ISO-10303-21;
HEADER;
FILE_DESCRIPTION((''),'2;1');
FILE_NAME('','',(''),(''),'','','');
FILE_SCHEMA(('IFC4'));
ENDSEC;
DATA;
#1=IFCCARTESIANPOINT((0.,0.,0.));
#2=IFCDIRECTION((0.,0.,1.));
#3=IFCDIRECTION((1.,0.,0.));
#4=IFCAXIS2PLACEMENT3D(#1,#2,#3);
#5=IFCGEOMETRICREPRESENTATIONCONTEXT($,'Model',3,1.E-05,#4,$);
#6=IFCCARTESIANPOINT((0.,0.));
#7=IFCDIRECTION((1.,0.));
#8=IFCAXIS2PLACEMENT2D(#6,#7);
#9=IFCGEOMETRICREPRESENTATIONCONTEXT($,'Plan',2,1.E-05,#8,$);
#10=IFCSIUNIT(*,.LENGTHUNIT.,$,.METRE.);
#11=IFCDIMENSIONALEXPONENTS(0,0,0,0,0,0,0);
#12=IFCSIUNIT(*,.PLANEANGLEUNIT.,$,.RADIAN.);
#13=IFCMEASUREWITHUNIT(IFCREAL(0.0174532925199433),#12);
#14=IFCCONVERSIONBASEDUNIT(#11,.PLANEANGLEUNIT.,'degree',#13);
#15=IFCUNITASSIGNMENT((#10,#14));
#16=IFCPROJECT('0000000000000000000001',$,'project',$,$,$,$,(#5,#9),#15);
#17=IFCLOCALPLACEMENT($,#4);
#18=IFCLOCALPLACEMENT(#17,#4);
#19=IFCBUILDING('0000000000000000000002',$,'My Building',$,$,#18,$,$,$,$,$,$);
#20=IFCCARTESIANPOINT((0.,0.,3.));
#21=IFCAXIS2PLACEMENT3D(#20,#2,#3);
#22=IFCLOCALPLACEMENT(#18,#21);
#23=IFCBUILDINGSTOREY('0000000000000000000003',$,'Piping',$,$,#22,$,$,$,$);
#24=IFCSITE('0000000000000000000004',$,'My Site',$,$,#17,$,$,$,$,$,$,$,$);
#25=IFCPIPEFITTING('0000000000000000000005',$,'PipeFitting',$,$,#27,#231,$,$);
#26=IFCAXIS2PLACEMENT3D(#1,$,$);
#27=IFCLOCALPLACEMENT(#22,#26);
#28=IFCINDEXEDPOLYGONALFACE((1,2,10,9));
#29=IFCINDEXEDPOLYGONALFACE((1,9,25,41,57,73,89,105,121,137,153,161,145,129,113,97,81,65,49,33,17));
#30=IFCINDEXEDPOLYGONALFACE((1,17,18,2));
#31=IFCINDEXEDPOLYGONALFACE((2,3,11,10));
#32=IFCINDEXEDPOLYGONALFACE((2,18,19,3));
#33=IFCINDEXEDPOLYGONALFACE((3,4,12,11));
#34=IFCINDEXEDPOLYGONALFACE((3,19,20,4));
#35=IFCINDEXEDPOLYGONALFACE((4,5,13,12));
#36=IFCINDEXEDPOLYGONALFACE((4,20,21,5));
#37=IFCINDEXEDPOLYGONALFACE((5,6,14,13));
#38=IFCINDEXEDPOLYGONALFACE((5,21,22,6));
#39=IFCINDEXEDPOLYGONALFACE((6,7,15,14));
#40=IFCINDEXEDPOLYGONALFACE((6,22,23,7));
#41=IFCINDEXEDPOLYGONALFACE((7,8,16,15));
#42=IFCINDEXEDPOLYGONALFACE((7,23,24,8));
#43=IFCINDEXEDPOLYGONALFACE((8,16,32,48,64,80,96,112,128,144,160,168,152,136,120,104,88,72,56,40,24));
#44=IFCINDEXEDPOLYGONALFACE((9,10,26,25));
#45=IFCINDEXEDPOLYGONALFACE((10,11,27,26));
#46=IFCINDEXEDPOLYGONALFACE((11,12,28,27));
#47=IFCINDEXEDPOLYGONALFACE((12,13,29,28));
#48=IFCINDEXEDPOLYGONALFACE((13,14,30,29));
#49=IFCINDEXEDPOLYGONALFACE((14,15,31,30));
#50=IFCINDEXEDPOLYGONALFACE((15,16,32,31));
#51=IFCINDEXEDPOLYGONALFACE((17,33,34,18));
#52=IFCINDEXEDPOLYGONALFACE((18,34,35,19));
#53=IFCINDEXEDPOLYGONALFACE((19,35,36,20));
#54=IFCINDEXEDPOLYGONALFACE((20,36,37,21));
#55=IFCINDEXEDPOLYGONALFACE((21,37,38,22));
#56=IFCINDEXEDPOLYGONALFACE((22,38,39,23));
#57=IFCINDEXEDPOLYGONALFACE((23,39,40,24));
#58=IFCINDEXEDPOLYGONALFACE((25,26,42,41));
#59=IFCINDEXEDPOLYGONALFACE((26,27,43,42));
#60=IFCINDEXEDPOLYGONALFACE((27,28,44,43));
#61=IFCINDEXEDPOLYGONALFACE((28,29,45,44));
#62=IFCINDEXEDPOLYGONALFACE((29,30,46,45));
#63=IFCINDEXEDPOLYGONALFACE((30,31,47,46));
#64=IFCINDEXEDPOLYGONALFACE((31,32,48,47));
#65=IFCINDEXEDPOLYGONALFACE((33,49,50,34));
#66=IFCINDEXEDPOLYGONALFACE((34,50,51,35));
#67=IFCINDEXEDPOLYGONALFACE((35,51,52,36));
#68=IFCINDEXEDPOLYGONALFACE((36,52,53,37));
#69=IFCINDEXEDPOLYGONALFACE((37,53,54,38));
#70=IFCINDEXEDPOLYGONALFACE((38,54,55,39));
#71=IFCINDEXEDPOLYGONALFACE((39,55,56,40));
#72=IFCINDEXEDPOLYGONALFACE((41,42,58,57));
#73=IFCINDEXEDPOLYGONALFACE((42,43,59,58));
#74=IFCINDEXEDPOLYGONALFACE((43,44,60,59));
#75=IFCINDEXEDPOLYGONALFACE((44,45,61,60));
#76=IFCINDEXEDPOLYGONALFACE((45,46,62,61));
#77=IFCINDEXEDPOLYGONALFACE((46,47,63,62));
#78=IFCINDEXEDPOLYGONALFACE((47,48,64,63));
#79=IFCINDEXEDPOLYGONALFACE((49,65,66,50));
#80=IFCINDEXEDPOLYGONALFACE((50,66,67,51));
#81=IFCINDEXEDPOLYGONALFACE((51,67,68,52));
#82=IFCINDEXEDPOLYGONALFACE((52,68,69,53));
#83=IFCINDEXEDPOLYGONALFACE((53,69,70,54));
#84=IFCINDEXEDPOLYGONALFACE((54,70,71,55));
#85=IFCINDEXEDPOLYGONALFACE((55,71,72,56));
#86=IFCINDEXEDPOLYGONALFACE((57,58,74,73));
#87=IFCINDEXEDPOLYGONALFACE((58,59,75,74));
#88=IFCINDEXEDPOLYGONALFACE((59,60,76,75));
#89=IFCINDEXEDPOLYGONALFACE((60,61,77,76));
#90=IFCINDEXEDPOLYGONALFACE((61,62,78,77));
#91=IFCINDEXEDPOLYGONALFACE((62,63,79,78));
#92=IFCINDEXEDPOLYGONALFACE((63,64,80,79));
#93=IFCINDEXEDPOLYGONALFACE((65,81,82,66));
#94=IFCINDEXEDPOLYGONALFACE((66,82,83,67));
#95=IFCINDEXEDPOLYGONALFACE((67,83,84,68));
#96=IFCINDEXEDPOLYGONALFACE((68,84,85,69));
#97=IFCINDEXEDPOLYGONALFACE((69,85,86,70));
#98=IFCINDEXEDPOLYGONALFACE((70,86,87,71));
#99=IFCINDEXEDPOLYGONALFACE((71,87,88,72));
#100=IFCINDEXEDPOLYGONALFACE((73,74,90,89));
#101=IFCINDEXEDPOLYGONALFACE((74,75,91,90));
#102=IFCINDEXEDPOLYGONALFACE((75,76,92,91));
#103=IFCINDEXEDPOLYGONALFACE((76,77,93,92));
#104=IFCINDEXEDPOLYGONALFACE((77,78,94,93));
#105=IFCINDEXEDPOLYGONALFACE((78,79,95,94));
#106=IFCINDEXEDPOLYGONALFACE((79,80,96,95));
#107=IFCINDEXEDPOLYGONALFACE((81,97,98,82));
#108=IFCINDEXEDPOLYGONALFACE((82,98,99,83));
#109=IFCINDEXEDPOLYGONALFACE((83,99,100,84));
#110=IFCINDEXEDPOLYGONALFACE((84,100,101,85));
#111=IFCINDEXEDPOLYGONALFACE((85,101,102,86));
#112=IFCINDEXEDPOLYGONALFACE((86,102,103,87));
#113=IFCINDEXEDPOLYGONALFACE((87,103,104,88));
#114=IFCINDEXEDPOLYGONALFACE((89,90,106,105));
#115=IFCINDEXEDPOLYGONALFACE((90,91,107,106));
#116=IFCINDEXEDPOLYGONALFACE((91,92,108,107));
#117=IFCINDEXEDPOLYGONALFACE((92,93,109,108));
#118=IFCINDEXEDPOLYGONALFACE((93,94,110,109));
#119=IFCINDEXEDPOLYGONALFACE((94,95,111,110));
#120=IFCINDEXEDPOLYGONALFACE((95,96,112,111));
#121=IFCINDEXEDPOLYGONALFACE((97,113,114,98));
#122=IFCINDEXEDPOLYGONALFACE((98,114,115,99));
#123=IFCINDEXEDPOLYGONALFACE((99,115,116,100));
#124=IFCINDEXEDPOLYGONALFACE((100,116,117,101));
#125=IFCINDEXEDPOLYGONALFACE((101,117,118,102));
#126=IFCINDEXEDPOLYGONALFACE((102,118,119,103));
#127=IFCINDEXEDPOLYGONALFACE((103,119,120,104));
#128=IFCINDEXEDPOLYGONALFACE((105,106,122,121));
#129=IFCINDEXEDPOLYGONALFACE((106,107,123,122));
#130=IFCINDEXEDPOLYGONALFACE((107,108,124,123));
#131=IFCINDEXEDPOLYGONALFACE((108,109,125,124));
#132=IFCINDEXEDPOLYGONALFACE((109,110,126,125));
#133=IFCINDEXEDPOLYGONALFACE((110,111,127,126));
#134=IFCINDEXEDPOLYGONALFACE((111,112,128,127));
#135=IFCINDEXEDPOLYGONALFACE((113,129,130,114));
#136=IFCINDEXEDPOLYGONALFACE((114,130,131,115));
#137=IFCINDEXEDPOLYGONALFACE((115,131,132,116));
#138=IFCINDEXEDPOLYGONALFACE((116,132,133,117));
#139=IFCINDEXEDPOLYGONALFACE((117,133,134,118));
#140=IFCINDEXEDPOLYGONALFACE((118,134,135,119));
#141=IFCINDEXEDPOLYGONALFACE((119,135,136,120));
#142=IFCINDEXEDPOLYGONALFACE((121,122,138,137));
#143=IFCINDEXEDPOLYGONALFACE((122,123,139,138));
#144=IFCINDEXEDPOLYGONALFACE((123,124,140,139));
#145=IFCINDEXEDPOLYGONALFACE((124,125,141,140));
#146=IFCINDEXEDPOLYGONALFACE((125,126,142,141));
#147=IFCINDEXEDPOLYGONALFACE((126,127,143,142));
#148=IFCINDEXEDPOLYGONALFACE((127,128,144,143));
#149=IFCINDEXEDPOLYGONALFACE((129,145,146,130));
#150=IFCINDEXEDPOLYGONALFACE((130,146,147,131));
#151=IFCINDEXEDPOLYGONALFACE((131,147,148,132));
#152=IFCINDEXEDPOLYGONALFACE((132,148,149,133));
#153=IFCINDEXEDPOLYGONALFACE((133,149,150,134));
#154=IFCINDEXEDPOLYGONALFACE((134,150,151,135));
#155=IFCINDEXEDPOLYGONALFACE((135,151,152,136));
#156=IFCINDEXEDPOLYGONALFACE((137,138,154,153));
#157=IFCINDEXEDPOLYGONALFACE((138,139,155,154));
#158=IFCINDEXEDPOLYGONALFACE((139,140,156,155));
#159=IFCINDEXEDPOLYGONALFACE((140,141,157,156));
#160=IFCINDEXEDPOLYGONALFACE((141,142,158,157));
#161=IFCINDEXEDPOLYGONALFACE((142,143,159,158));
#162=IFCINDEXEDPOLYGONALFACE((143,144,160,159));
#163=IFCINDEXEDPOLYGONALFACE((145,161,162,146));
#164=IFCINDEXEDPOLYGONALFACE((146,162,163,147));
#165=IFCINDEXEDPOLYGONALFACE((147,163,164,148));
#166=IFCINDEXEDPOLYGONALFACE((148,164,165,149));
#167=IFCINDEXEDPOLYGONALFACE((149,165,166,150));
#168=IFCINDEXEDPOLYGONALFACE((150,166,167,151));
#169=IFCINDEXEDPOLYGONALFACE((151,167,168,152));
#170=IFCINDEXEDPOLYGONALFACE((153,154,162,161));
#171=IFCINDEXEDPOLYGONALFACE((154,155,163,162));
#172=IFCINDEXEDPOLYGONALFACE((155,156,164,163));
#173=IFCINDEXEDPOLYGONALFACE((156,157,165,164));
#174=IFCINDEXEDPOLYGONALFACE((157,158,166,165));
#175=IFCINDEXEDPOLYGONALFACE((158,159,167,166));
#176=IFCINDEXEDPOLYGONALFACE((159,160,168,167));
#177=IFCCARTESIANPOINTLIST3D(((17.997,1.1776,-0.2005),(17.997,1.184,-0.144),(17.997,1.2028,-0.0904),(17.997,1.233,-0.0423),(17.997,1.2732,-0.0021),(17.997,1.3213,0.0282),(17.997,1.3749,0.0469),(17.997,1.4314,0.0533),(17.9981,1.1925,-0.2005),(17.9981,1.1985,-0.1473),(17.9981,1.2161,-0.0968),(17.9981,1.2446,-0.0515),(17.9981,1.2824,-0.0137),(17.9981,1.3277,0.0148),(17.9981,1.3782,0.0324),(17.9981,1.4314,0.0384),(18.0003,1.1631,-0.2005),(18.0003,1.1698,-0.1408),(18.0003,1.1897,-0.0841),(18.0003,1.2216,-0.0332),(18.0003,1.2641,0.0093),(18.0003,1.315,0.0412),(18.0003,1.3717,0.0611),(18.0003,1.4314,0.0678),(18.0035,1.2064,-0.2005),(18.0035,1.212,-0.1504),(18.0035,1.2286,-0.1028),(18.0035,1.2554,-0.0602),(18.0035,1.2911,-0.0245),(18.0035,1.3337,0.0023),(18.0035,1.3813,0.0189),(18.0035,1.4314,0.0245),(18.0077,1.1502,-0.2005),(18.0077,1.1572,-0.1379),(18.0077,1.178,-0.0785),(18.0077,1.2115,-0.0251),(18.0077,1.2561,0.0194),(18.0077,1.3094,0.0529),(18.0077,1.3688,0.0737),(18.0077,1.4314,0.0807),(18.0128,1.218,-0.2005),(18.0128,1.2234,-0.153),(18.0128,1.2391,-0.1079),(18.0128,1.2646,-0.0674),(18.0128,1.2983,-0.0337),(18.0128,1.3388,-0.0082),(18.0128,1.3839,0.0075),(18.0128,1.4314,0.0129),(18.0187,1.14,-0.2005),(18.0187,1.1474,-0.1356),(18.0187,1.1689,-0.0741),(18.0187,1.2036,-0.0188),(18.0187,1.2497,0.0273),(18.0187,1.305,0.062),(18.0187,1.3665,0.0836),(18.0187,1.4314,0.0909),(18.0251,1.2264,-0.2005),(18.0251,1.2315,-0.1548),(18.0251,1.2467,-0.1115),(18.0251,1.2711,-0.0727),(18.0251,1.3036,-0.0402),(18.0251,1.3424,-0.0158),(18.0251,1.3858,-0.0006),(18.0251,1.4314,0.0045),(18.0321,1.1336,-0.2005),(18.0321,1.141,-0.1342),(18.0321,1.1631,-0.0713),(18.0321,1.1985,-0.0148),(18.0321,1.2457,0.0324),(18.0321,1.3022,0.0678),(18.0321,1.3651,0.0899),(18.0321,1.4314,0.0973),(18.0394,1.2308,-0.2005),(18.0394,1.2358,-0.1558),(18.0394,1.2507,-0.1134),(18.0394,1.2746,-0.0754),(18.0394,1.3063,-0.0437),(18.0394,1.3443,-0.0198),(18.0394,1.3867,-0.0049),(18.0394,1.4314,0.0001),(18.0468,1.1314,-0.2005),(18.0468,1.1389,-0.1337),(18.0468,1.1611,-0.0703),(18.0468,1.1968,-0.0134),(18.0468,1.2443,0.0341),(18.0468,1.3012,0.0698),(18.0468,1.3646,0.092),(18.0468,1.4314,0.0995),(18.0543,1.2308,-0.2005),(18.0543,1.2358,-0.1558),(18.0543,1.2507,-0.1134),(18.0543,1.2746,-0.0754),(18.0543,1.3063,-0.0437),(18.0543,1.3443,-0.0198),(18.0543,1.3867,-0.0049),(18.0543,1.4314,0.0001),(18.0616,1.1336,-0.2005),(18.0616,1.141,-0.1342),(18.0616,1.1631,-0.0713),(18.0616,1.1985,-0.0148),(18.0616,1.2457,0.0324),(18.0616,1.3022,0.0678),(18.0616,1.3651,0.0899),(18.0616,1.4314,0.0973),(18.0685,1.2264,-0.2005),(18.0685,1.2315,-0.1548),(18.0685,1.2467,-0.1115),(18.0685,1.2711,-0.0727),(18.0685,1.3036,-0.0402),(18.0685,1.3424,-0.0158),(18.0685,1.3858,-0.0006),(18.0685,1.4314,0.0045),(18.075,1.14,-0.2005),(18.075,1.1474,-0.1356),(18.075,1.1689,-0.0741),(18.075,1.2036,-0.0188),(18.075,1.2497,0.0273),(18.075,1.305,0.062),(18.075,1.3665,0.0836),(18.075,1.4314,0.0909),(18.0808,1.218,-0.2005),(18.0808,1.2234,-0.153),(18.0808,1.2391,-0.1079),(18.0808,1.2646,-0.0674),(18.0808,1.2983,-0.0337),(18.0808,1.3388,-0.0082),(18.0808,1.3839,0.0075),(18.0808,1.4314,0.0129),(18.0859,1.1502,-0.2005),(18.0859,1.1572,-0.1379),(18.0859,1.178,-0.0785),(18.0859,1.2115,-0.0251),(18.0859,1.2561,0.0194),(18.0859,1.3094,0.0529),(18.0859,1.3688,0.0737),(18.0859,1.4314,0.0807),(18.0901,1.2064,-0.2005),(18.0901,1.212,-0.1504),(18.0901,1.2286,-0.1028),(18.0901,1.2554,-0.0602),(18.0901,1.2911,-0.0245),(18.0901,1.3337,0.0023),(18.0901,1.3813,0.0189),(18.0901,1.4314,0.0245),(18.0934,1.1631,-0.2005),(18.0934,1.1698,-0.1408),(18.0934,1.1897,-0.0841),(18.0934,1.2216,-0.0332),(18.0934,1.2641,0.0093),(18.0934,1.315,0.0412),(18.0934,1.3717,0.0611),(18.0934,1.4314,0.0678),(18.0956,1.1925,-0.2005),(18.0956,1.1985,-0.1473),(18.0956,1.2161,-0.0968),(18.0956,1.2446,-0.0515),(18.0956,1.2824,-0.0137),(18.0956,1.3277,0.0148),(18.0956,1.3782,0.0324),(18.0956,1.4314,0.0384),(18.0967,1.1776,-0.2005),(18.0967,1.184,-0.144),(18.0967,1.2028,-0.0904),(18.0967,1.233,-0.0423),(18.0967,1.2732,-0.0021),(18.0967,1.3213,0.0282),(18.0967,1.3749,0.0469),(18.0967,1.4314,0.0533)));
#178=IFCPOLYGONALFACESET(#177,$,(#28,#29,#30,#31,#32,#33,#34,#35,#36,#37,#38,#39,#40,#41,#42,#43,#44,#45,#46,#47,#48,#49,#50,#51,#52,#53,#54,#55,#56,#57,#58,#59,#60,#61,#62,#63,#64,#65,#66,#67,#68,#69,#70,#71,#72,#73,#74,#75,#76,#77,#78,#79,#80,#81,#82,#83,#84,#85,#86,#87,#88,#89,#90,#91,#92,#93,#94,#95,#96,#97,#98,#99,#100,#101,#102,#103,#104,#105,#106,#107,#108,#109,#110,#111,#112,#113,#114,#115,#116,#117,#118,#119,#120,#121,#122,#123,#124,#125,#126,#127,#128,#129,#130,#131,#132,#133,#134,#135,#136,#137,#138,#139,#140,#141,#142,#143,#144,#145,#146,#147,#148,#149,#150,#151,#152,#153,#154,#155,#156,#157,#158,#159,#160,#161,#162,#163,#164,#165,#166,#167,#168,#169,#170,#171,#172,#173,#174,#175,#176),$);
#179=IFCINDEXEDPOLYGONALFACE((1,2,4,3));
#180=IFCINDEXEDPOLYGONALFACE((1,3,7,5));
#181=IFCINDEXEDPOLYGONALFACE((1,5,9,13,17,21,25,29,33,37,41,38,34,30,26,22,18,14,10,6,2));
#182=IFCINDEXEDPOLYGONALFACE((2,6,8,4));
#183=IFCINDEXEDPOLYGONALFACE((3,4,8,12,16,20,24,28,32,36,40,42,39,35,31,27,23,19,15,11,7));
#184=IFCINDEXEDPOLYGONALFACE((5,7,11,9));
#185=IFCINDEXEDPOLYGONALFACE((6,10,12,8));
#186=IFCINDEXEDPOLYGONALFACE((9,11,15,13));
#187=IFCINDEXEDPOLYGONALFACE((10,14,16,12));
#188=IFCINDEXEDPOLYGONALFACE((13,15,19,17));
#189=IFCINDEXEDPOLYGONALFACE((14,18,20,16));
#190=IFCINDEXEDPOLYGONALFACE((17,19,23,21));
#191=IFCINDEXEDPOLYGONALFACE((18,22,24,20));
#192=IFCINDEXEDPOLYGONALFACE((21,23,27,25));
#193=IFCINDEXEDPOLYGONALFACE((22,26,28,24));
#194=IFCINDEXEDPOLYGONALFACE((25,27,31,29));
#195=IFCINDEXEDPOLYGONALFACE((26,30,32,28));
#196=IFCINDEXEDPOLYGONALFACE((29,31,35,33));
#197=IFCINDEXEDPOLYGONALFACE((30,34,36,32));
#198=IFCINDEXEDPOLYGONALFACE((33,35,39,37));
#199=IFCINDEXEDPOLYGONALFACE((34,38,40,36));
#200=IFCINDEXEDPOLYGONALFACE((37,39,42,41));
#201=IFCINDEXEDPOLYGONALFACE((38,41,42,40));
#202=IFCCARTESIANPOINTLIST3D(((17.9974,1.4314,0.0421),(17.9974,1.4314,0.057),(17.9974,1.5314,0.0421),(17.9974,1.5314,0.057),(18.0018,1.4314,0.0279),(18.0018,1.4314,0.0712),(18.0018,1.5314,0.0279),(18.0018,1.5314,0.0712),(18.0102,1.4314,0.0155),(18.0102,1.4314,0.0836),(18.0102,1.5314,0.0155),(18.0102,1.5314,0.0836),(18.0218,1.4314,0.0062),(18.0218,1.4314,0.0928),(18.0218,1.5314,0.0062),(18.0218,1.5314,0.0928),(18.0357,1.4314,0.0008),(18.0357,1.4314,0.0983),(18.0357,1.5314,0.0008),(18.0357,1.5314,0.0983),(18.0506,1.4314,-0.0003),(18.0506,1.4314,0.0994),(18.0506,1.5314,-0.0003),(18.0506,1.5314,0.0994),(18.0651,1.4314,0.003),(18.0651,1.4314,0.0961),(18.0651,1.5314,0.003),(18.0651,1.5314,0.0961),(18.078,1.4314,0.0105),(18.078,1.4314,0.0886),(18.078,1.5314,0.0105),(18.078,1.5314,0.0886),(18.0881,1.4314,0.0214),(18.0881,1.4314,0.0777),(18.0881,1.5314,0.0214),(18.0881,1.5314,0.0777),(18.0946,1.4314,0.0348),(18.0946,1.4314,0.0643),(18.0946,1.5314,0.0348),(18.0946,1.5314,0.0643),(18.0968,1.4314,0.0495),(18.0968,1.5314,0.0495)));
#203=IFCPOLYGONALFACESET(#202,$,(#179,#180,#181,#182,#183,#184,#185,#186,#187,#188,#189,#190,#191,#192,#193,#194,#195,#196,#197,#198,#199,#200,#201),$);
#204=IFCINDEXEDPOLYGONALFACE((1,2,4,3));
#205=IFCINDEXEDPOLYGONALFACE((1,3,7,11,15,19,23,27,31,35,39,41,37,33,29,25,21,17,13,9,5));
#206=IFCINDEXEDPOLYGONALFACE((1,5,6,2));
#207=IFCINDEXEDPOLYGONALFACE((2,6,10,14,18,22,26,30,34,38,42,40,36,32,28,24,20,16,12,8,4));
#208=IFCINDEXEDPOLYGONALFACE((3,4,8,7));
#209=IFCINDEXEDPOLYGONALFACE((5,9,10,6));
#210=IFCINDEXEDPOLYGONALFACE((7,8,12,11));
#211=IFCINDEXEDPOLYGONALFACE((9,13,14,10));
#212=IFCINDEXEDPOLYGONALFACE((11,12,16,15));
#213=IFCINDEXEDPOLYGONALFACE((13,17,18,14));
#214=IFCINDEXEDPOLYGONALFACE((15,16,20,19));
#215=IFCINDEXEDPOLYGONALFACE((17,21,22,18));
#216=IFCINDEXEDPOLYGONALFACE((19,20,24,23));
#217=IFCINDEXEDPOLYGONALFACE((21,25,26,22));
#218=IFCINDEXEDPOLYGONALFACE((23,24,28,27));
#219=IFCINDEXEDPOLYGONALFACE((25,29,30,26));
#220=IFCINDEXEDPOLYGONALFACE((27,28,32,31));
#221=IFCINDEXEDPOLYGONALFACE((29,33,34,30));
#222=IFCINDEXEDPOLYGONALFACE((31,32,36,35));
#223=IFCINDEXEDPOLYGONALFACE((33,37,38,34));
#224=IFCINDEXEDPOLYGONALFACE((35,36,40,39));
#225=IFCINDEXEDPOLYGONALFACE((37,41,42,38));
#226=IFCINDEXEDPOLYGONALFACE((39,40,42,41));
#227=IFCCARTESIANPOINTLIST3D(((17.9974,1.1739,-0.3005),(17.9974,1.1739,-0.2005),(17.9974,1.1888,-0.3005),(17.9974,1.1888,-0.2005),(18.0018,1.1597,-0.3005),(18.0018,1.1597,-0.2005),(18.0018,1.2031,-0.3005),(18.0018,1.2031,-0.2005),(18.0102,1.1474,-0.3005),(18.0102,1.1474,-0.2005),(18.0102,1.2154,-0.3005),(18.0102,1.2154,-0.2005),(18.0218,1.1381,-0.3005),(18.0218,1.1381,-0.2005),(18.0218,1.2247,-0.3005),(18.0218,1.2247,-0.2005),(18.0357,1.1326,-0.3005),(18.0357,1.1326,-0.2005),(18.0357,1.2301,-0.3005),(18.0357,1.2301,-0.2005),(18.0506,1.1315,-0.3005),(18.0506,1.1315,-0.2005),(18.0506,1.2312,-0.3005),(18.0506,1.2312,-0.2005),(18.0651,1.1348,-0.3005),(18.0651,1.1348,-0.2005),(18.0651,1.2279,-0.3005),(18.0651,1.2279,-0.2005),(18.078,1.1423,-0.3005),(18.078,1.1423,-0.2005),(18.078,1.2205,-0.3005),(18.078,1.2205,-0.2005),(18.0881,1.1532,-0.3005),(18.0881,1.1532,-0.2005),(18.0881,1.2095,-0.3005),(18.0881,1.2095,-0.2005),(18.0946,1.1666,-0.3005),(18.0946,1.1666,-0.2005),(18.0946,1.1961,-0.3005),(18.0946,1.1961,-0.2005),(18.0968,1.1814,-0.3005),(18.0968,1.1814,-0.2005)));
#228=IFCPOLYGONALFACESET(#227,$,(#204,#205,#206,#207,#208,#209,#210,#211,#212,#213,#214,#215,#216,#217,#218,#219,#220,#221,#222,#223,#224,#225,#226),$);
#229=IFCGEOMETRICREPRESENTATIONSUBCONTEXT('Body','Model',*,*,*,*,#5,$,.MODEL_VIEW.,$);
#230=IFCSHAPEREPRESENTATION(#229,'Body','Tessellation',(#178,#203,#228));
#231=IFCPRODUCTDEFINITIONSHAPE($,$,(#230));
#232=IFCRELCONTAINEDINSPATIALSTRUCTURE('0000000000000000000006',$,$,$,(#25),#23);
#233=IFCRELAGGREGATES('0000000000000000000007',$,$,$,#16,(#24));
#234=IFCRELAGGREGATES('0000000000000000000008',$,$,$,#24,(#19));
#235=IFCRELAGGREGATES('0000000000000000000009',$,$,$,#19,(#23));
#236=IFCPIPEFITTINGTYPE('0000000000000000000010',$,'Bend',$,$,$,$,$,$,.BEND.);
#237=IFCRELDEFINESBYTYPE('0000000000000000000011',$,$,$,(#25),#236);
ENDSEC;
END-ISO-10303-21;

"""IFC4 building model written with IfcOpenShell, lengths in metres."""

from ifc_helpers import new_model, entity, si_unit, converted_unit, frame, origin_with_axes, origin_2d_with_axis, place, context, subcontext, project, spatial, circle, extrude, source, transform, mapped, type_object, type_shapes, element, save


model = new_model("IFC4")

# Units and contexts
model_context = context("Model", 3, precision=1e-05, world=origin_with_axes())
plan_context = context("Plan", 2, precision=1e-05, world=origin_2d_with_axis())
body_context = subcontext(model_context, "Body", "Model", "MODEL_VIEW")
ifc_project = project(units=[si_unit("LENGTHUNIT", "METRE"), converted_unit("PLANEANGLEUNIT", "degree", entity("IfcReal", 0.0174532925199433), si_unit("PLANEANGLEUNIT", "RADIAN"), dimensions=[0, 0, 0, 0, 0, 0, 0])], contexts=[model_context, plan_context])

# Site, building, storey
site_placement = place(None, origin_with_axes())
site = spatial("IfcSite", under=ifc_project, at=site_placement, Name="My Site")
building_placement = place(site_placement, origin_with_axes())
building = spatial("IfcBuilding", under=site, at=building_placement, Name="My Building")
storey_placement = place(building_placement, frame((0.0, 0.0, 3.0), z_axis=(0.0, 0.0, 1.0), x_axis=(1.0, 0.0, 0.0)))
storey = spatial("IfcBuildingStorey", under=building, at=storey_placement, Name="Piping")

# Pipe fitting
pipe_fitting_type = type_object("IfcPipeFittingType", Name="Bend", PredefinedType="BEND")
shared_shape = source(origin_with_axes(), body_context, "Body", "SolidModel", [
    entity("IfcSweptDiskSolid", entity("IfcIndexedPolyCurve", entity("IfcCartesianPointList3D", [[0.0, 0.0, 0.1], [0.0, -0.0732, 0.2768], [0.0, -0.25, 0.35]]), [entity("IfcArcIndex", [1, 2, 3])]), 0.05),
    extrude(circle(Radius=0.05), origin_with_axes(), (0.0, 0.0, 1.0), 0.1),
    extrude(circle(Radius=0.05), frame((0.0, -0.25, 0.35), z_axis=(0.0, -1.0, 0.0), x_axis=(1.0, 0.0, 0.0)), (0.0, 0.0, 1.0), 0.1),
])
type_shapes(pipe_fitting_type, [shared_shape])
for number, where, z_axis, x_axis, name in (
    (1, (18.0468, 1.5314, 0.0495), (0.0, -1.0, 0.0), (1.0, 0.0, 0.0), "PipeFitting"),
):
    element("IfcPipeFitting", number, at=place(storey_placement, frame(where, z_axis=z_axis, x_axis=x_axis)), inside=storey, type_object=pipe_fitting_type, Name=name, context=body_context, shape_type="MappedRepresentation", body=[
        mapped(shared_shape, transform((0.0, 0.0, 0.0), x_axis=(1.0, 0.0, 0.0), y_axis=(0.0, 1.0, 0.0), z_axis=(0.0, 0.0, 1.0), scale=1.0)),
    ])

save(model, "model.ifc")
